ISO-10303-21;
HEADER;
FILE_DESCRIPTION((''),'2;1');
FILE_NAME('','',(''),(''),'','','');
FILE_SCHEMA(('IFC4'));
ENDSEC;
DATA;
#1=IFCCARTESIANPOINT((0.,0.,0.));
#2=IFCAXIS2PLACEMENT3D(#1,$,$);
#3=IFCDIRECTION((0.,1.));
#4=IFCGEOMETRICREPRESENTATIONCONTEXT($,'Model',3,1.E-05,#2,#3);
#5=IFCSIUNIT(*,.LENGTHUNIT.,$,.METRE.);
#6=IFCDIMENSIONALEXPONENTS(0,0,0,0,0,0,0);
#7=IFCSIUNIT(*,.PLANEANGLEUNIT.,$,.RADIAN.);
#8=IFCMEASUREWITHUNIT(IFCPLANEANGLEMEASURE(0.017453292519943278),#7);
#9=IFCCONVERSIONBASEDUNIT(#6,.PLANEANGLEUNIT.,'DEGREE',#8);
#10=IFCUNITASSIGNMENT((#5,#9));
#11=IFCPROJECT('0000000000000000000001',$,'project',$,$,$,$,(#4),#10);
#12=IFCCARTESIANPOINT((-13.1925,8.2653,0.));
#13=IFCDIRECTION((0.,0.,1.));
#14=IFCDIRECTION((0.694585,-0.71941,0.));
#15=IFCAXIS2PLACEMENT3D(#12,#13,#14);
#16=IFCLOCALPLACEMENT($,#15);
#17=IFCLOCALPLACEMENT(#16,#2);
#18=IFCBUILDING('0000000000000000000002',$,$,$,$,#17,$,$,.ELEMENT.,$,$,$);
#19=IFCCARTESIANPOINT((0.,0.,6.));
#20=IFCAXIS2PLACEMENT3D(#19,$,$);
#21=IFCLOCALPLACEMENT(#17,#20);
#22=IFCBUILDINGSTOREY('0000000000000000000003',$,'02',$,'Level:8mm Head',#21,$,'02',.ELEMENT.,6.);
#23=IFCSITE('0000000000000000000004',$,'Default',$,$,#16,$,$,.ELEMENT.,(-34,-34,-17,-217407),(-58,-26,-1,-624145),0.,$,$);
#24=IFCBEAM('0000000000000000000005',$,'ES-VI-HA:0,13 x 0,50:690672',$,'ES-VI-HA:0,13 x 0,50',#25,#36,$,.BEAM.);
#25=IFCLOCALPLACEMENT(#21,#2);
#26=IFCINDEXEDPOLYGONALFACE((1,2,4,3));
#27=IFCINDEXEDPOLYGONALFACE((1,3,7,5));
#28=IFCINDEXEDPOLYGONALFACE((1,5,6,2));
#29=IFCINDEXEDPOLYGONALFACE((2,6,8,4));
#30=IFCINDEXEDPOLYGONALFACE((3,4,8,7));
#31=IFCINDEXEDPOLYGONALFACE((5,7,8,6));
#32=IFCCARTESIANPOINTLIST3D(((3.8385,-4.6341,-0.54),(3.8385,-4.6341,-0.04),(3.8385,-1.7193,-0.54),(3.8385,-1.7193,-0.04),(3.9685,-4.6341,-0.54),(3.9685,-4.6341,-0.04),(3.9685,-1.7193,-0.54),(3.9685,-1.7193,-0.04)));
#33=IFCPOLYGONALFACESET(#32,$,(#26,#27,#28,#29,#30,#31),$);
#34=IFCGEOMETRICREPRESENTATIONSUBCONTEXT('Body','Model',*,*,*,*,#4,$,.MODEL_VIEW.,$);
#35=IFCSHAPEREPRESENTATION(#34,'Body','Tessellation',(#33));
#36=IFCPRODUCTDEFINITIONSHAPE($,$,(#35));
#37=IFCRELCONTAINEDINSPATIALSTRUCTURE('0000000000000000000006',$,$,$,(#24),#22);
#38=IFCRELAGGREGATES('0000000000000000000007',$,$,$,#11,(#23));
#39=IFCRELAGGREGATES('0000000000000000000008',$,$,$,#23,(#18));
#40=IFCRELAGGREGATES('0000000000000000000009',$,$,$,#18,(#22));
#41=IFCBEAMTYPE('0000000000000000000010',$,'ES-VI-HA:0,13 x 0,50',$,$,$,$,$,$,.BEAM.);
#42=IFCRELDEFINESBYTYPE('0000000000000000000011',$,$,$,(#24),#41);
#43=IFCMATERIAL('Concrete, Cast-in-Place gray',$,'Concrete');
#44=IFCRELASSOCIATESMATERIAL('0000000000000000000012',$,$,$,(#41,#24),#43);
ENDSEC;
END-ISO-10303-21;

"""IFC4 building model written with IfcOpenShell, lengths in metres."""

from ifc_helpers import new_model, entity, si_unit, converted_unit, direction, frame, origin, place, context, subcontext, project, spatial, indexed_curve, outline, extrude, source, transform, mapped, material, type_object, type_shapes, element, save


model = new_model("IFC4")

# Units and contexts
model_context = context("Model", 3, precision=1e-05, world=origin(), true_north=direction((0.0, 1.0)))
body_context = subcontext(model_context, "Body", "Model", "MODEL_VIEW")
ifc_project = project(units=[si_unit("LENGTHUNIT", "METRE"), converted_unit("PLANEANGLEUNIT", "DEGREE", entity("IfcPlaneAngleMeasure", 0.017453292519943278), si_unit("PLANEANGLEUNIT", "RADIAN"), dimensions=[0, 0, 0, 0, 0, 0, 0])], contexts=[model_context])

# Site, building, storey
site_placement = place(None, frame((-13.1925, 8.2653, 0.0), z_axis=(0.0, 0.0, 1.0), x_axis=(0.694585, -0.71941, 0.0)))
site = spatial("IfcSite", under=ifc_project, at=site_placement, Name="Default", CompositionType="ELEMENT", RefLatitude=(-34, -34, -17, -217407), RefLongitude=(-58, -26, -1, -624145), RefElevation=0.0)
building_placement = place(site_placement, origin())
building = spatial("IfcBuilding", under=site, at=building_placement, CompositionType="ELEMENT")
storey_placement = place(building_placement, frame((0.0, 0.0, 6.0)))
storey = spatial("IfcBuildingStorey", under=building, at=storey_placement, Name="02", ObjectType="Level:8mm Head", LongName="02", CompositionType="ELEMENT", Elevation=6.0)

# Beam
ifc_material = material(Name="Concrete, Cast-in-Place gray", Category="Concrete")
beam_type_1 = type_object("IfcBeamType", Name="ES-VI-HA:0,13 x 0,50", PredefinedType="BEAM", material=ifc_material)
shared_shape_1 = source(origin(), body_context, "Body", "SweptSolid", [
    extrude(outline(indexed_curve([(-0.065, -0.25), (0.065, -0.25), (0.065, 0.25), (-0.065, 0.25), (-0.065, -0.25)], self_intersect=False)), frame((3.9035, -4.6341, 5.71), z_axis=(0.0, 1.0, 0.0), x_axis=(-1.0, 0.0, 0.0)), (0.0, 0.0, 1.0), 2.9148),
])
type_shapes(beam_type_1, [shared_shape_1])
beam_1_placement = place(storey_placement, frame((0.0, 0.0, -6.0)))
element("IfcBeam", 1, at=beam_1_placement, inside=storey, type_object=beam_type_1, material=ifc_material, Name="ES-VI-HA:0,13 x 0,50:690672", ObjectType="ES-VI-HA:0,13 x 0,50", PredefinedType="BEAM", context=body_context, shape_type="MappedRepresentation", body=[
    mapped(shared_shape_1, transform((0.0, 0.0, 0.0), scale=1.0)),
])

save(model, "model.ifc")
